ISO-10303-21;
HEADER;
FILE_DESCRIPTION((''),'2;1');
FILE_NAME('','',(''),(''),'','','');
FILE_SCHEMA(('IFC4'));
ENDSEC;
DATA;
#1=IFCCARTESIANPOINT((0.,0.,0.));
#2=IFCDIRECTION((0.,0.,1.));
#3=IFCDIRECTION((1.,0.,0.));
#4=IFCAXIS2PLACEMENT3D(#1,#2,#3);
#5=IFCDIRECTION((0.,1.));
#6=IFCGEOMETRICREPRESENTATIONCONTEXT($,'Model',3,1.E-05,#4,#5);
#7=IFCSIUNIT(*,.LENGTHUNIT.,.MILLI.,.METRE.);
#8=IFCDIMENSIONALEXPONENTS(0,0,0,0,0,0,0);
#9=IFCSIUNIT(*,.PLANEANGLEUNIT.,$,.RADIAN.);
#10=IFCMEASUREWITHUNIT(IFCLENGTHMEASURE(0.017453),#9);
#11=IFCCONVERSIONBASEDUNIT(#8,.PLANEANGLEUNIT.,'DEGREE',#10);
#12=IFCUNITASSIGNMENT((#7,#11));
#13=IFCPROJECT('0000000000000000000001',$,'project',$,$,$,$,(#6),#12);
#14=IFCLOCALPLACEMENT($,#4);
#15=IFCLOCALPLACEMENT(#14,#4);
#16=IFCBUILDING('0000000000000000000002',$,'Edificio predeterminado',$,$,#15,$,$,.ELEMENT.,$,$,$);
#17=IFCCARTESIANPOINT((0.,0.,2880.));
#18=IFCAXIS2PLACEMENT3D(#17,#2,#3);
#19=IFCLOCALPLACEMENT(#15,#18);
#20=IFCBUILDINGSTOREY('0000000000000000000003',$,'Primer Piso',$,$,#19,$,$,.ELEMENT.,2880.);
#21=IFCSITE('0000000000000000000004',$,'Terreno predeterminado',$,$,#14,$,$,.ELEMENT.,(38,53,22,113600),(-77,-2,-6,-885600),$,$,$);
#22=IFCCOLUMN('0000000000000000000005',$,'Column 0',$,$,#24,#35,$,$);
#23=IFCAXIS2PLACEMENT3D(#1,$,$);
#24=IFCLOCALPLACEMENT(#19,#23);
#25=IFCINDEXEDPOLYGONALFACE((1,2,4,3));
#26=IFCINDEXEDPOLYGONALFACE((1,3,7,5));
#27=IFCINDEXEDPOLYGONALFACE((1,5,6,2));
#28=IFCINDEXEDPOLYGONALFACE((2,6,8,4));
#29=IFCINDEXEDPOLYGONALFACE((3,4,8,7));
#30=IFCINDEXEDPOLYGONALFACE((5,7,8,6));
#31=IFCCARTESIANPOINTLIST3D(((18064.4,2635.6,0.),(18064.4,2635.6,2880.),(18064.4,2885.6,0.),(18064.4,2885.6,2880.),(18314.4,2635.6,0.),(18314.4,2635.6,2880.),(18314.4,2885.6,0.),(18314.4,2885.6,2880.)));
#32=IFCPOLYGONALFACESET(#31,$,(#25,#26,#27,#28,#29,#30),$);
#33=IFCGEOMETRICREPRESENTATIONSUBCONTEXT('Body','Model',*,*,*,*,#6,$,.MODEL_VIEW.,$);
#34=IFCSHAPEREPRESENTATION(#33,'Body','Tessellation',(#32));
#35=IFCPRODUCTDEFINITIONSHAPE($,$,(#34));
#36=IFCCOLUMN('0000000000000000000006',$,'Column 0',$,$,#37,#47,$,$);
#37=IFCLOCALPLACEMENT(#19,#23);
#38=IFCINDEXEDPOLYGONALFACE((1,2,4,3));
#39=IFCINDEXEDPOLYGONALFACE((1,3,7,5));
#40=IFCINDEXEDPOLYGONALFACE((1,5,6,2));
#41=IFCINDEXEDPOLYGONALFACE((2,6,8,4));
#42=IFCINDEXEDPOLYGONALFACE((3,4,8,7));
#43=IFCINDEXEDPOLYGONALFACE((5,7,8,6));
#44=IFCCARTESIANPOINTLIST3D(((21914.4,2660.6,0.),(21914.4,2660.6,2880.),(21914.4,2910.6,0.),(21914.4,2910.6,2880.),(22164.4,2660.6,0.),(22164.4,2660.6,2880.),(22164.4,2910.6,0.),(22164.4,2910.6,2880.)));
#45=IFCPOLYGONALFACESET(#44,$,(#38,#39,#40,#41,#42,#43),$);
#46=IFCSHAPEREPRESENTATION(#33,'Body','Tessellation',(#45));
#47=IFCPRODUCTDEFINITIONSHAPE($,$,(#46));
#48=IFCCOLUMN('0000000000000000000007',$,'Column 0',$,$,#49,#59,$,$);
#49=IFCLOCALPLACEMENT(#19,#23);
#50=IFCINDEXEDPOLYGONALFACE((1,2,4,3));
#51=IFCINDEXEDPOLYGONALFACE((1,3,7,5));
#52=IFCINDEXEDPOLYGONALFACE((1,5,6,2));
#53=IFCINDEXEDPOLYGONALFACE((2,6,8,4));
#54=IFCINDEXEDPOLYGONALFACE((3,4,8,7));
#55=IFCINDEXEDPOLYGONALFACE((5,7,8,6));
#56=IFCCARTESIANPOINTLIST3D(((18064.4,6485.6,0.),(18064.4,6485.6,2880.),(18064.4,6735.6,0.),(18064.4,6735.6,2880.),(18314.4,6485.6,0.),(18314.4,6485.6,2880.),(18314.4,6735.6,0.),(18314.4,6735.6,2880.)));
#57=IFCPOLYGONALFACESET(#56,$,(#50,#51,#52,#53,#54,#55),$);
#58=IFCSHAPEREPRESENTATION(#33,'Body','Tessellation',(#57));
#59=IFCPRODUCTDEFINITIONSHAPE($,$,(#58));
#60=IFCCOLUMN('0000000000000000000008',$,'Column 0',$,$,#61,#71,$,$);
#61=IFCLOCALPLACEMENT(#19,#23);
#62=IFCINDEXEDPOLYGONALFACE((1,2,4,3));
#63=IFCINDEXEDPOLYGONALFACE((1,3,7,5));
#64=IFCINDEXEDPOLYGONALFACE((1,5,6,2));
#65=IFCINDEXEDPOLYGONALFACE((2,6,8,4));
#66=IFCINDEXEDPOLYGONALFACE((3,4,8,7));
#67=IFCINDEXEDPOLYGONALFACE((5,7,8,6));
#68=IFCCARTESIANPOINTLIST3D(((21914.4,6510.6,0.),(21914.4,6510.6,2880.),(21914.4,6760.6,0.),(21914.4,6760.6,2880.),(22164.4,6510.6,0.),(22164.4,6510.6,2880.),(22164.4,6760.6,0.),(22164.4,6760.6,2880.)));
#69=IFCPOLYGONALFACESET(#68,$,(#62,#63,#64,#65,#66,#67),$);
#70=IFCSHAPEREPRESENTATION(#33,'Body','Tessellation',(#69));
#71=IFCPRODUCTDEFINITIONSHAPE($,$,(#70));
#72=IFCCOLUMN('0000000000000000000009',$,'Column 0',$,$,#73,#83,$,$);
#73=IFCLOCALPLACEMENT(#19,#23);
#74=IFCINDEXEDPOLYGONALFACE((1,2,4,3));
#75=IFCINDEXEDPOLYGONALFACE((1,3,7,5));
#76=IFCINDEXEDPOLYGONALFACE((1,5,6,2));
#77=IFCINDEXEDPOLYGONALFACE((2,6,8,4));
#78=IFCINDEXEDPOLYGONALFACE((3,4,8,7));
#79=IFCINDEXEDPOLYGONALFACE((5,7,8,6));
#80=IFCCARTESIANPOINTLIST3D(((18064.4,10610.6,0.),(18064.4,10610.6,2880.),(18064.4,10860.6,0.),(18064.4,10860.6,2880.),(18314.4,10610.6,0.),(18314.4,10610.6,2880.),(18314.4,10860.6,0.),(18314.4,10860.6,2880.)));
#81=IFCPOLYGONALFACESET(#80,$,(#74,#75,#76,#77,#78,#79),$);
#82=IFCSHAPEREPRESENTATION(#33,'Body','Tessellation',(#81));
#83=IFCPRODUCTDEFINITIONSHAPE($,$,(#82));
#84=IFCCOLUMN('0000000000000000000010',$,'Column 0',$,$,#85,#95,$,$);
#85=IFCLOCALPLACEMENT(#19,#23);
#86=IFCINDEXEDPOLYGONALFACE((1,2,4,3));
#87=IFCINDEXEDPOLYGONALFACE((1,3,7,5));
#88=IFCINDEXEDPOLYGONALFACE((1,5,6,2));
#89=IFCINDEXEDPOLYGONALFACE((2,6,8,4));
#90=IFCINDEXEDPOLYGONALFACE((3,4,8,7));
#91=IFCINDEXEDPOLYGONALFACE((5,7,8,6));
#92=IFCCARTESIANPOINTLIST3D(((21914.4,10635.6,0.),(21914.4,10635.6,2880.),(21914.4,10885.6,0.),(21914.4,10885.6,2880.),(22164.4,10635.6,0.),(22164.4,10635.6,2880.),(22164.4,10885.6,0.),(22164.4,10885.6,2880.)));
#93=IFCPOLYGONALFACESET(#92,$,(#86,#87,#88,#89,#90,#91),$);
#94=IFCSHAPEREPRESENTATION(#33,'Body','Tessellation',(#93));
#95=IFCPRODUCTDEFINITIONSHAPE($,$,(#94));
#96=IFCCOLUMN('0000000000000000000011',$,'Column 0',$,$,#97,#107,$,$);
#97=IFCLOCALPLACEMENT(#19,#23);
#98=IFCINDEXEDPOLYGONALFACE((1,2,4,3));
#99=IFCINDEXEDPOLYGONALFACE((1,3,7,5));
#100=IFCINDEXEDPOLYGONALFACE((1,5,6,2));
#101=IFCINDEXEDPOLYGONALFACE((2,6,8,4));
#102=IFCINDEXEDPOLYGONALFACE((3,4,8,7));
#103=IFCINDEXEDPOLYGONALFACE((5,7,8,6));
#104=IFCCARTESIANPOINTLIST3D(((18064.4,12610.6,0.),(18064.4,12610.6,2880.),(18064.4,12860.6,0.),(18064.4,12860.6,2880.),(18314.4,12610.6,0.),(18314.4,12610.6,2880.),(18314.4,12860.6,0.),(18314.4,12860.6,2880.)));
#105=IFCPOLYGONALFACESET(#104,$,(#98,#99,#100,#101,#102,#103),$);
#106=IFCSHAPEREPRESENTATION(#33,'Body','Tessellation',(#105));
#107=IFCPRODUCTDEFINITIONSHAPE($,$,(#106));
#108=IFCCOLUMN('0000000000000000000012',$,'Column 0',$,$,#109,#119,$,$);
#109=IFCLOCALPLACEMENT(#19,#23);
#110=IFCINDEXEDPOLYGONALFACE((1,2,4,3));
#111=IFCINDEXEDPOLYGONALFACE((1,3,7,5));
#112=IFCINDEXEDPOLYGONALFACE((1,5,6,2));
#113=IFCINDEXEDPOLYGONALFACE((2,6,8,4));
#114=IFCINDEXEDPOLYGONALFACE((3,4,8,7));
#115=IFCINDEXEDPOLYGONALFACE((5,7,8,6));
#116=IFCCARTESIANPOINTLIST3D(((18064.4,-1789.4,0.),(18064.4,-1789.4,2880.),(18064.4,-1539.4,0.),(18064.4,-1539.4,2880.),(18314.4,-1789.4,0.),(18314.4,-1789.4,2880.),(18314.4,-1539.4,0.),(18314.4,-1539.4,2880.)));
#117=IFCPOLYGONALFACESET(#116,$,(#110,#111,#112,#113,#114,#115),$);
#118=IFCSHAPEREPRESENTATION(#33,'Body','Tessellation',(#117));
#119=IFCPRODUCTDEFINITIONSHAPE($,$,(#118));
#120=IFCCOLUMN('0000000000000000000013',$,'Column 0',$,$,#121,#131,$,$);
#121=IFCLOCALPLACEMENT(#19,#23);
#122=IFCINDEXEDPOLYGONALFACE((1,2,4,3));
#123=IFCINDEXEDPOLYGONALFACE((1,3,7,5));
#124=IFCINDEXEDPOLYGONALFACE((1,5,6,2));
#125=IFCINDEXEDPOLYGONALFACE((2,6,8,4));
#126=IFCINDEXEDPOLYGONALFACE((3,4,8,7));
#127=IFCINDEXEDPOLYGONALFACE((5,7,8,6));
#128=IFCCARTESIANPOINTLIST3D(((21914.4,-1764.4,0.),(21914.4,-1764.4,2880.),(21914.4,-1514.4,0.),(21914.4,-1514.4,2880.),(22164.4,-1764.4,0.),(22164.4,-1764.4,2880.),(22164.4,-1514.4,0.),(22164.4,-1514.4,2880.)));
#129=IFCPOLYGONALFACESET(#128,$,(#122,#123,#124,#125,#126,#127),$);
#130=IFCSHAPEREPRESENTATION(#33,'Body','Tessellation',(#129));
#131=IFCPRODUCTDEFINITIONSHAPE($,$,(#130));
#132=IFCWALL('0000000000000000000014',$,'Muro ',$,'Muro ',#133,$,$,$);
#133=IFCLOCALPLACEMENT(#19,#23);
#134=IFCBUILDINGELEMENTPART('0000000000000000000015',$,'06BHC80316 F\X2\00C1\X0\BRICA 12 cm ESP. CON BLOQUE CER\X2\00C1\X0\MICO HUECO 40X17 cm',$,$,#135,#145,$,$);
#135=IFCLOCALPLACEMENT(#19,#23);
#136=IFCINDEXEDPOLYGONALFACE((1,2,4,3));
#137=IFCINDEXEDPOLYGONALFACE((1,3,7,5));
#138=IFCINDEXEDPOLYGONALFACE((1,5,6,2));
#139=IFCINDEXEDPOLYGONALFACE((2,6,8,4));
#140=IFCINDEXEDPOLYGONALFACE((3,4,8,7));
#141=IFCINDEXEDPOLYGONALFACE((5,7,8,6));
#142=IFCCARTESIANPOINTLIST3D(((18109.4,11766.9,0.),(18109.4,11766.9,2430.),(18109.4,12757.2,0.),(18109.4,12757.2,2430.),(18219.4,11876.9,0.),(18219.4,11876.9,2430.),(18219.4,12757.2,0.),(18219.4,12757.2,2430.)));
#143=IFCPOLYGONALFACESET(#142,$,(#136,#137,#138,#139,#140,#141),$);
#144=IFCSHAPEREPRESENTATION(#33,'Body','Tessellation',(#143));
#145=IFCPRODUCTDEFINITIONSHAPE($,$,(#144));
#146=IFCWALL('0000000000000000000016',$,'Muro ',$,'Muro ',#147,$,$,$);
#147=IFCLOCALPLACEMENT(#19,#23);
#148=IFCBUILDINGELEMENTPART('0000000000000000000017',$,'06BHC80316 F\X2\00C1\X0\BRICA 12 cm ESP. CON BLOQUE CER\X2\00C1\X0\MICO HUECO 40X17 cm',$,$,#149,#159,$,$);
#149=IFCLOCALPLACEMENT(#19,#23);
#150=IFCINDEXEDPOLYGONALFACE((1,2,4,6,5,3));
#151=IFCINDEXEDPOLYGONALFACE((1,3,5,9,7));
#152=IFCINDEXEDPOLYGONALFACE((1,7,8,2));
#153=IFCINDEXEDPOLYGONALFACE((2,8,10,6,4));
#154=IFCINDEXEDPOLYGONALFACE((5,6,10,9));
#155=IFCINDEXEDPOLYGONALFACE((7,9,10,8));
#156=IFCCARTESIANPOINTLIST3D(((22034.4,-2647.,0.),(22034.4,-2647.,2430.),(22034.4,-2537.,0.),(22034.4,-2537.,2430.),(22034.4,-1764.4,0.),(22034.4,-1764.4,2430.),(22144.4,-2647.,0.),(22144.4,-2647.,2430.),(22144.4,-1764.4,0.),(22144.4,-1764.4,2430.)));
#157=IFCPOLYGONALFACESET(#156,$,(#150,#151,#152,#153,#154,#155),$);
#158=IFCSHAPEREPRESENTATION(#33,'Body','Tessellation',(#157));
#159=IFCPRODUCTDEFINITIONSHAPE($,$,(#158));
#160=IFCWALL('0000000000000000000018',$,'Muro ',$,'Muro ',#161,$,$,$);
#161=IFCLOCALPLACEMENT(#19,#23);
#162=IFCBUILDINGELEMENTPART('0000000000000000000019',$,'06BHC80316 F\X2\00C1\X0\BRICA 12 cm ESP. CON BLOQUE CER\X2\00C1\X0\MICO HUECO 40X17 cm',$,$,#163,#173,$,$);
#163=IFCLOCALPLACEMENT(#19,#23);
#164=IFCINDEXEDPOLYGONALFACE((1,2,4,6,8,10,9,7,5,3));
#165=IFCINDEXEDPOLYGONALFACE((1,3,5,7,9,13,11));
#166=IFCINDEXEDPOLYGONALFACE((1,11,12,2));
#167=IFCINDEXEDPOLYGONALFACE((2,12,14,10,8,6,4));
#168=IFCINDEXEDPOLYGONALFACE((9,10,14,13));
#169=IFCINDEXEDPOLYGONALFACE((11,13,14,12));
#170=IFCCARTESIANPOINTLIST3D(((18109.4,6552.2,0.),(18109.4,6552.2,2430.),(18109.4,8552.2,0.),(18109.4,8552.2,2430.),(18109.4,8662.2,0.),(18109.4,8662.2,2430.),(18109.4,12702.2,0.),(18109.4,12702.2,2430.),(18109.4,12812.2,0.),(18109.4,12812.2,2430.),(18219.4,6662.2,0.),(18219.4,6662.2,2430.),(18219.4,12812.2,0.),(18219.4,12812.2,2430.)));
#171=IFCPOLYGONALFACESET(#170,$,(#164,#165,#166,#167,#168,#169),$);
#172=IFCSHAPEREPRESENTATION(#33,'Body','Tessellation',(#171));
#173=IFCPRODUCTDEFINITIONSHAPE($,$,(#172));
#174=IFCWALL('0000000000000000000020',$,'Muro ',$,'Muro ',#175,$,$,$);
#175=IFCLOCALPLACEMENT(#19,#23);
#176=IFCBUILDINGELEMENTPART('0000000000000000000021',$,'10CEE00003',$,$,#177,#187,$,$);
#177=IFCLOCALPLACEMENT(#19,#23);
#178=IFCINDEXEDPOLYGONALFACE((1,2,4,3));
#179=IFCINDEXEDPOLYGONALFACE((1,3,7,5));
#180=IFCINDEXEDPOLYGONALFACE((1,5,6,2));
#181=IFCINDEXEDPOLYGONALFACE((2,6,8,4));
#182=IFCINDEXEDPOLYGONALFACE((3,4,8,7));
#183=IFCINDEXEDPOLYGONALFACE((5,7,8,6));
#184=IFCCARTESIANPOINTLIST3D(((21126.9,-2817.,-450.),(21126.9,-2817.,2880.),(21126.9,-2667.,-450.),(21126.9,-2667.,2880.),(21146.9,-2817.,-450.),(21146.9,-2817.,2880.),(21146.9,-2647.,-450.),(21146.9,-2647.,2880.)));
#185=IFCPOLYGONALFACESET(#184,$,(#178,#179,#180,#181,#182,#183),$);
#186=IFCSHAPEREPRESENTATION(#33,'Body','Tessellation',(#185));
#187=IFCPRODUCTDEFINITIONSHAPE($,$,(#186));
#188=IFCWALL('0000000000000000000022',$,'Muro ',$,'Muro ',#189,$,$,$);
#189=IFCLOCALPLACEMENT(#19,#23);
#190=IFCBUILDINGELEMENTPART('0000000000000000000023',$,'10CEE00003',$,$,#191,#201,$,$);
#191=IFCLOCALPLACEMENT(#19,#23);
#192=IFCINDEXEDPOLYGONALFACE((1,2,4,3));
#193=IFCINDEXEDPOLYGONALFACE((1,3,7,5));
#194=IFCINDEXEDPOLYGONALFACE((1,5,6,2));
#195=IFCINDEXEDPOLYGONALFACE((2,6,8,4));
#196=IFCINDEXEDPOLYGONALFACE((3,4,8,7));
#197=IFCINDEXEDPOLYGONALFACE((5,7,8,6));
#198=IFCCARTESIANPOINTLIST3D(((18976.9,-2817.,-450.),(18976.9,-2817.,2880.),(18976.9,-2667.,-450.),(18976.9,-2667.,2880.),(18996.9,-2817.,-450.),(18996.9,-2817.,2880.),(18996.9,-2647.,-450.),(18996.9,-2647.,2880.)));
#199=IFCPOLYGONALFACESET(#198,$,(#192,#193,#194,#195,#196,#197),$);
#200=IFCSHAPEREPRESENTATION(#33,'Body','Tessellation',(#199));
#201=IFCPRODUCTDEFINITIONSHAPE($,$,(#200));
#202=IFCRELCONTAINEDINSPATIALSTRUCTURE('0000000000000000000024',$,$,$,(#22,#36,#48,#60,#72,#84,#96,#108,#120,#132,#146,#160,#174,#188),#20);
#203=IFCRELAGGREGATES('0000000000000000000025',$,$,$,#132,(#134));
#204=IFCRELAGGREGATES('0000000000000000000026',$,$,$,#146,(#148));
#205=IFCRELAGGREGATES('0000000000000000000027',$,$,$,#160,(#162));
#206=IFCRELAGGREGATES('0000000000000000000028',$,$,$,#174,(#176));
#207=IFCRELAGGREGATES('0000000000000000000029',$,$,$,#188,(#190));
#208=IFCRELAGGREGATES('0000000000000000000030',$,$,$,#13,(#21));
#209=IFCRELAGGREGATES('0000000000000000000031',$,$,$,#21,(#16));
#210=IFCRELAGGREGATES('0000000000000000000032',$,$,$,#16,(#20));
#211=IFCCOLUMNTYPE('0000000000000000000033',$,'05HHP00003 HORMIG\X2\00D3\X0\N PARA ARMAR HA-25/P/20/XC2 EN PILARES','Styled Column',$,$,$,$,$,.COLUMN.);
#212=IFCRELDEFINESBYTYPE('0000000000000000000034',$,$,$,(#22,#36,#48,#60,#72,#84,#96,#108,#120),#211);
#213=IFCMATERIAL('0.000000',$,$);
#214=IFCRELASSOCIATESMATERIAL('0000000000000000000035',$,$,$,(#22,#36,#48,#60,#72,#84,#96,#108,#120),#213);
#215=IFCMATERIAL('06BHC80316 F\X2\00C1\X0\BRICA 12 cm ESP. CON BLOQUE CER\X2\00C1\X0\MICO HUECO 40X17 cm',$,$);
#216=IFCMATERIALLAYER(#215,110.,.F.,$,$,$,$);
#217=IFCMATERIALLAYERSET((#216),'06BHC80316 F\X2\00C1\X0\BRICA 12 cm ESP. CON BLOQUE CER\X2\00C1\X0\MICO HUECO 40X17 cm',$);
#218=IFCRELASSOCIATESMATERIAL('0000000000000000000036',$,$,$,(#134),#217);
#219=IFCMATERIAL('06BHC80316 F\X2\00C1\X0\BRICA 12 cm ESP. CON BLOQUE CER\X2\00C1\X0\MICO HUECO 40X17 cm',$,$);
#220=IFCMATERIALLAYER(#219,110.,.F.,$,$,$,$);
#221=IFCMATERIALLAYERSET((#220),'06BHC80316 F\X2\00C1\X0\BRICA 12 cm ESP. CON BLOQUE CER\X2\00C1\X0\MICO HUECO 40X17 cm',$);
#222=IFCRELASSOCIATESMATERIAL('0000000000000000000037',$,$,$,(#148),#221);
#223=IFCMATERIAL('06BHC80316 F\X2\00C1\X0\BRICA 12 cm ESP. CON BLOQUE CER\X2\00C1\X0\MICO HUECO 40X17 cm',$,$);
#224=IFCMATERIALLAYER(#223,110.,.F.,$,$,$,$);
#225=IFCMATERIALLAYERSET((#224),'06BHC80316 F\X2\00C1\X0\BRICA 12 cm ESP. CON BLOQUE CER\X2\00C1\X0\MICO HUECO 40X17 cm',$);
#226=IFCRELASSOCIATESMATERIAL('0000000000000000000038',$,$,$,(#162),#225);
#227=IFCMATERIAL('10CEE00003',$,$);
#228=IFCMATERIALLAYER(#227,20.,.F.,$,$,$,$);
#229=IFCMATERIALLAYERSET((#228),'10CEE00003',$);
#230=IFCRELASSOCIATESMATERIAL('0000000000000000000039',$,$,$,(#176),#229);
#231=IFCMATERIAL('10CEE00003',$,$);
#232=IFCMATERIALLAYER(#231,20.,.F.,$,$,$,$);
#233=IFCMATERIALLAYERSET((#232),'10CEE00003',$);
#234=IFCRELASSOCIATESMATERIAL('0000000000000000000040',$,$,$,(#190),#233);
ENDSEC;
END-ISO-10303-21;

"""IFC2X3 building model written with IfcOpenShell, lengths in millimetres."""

from ifc_helpers import new_model, entity, si_unit, converted_unit, direction, frame, origin_with_axes, place, context, subcontext, project, spatial, polyline, outline, extrude, clip, bounded_halfspace, material, layer, layer_set, layer_usage, type_object, element, aggregate, save


model = new_model("IFC2X3")

# Units and contexts
model_context = context("Model", 3, precision=1e-05, world=origin_with_axes(), true_north=direction((0.0, 1.0)))
body_context = subcontext(model_context, "Body", "Model", "MODEL_VIEW")
ifc_project = project(units=[si_unit("LENGTHUNIT", "METRE", prefix="MILLI"), converted_unit("PLANEANGLEUNIT", "DEGREE", entity("IfcLengthMeasure", 0.017453), si_unit("PLANEANGLEUNIT", "RADIAN"), dimensions=[0, 0, 0, 0, 0, 0, 0])], contexts=[model_context])

# Site, building, storey
site_placement = place(None, origin_with_axes())
site = spatial("IfcSite", under=ifc_project, at=site_placement, Name="Terreno predeterminado", CompositionType="ELEMENT", RefLatitude=(38, 53, 22, 113600), RefLongitude=(-77, -2, -6, -885600))
building_placement = place(site_placement, origin_with_axes())
building = spatial("IfcBuilding", under=site, at=building_placement, Name="Edificio predeterminado", CompositionType="ELEMENT")
storey_placement = place(building_placement, frame((0.0, 0.0, 2880.0), z_axis=(0.0, 0.0, 1.0), x_axis=(1.0, 0.0, 0.0)))
storey = spatial("IfcBuildingStorey", under=building, at=storey_placement, Name="Primer Piso", CompositionType="ELEMENT", Elevation=2880.0)

# Columns
ifc_material_1 = material(Name="0.000000")
column_type = type_object("IfcColumnType", Name="05HHP00003 HORMIGÓN PARA ARMAR HA-25/P/20/XC2 EN PILARES", Description="Styled Column", PredefinedType="COLUMN")
for number, where, z_axis, x_axis, name in (
    (1, (18189.4, 2760.6, 0.0), (0.0, 0.0, 1.0), (1.0, 0.0, 0.0), "Column 0"),
    (2, (22039.4, 2785.6, 0.0), (0.0, 0.0, 1.0), (1.0, 0.0, 0.0), "Column 0"),
    (3, (18189.4, 6610.6, 0.0), (0.0, 0.0, 1.0), (1.0, 0.0, 0.0), "Column 0"),
    (4, (22039.4, 6635.6, 0.0), (0.0, 0.0, 1.0), (1.0, 0.0, 0.0), "Column 0"),
    (5, (18189.4, 10735.6, 0.0), (0.0, 0.0, 1.0), (1.0, 0.0, 0.0), "Column 0"),
    (6, (22039.4, 10760.6, 0.0), (0.0, 0.0, 1.0), (1.0, 0.0, 0.0), "Column 0"),
    (7, (18189.4, 12735.6, 0.0), (0.0, 0.0, 1.0), (1.0, 0.0, 0.0), "Column 0"),
    (8, (18189.4, -1664.4, 0.0), (0.0, 0.0, 1.0), (1.0, 0.0, 0.0), "Column 0"),
    (9, (22039.4, -1639.4, 0.0), (0.0, 0.0, 1.0), (1.0, 0.0, 0.0), "Column 0"),
):
    element("IfcColumn", number, at=place(storey_placement, frame(where, z_axis=z_axis, x_axis=x_axis)), inside=storey, type_object=column_type, material=ifc_material_1, Name=name, context=body_context, shape_type="SweptSolid", body=[
        extrude(outline(polyline([(-125.0, -125.0), (125.0, -125.0), (125.0, 125.0), (-125.0, 125.0), (-125.0, -125.0)])), origin_with_axes(), (0.0, 0.0, 1.0), 2880.0),
    ])

# Walls, building element parts
wall_1_placement = place(storey_placement, frame((18164.4, 11821.9, 0.0), z_axis=(0.0, 0.0, 1.0), x_axis=(0.0, 1.0, 0.0)))
wall_1 = element("IfcWall", 10, at=wall_1_placement, inside=storey, Name="Muro ", ObjectType="Muro ")
ifc_material_2 = material(Name="06BHC80316 FÁBRICA 12 cm ESP. CON BLOQUE CERÁMICO HUECO 40X17 cm")
ifc_layer_1 = layer(ifc_material_2, 110.0, ventilated=False)
ifc_layer_set_1 = layer_set([ifc_layer_1], Name="06BHC80316 FÁBRICA 12 cm ESP. CON BLOQUE CERÁMICO HUECO 40X17 cm")
ifc_layer_usage_1 = layer_usage(ifc_layer_set_1, "AXIS2", "NEGATIVE", -55.0)
building_element_part_1_placement = place(wall_1_placement, origin_with_axes())
building_element_part_1 = element("IfcBuildingElementPart", 11, at=building_element_part_1_placement, material=ifc_layer_usage_1, Name="06BHC80316 FÁBRICA 12 cm ESP. CON BLOQUE CERÁMICO HUECO 40X17 cm", context=body_context, shape_type="SweptSolid", body=[
    extrude(outline(polyline([(935.2, 55.0), (935.2, -55.0), (55.0, -55.0), (-55.0, 55.0), (935.2, 55.0)])), origin_with_axes(), (0.0, 0.0, 1.0), 2430.0),
])
aggregate(wall_1, [building_element_part_1])
wall_2_placement = place(storey_placement, frame((22089.4, -1764.4, 0.0), z_axis=(0.0, 0.0, 1.0), x_axis=(0.0, -1.0, 0.0)))
wall_2 = element("IfcWall", 12, at=wall_2_placement, inside=storey, Name="Muro ", ObjectType="Muro ")
ifc_material_3 = material(Name="06BHC80316 FÁBRICA 12 cm ESP. CON BLOQUE CERÁMICO HUECO 40X17 cm")
ifc_layer_2 = layer(ifc_material_3, 110.0, ventilated=False)
ifc_layer_set_2 = layer_set([ifc_layer_2], Name="06BHC80316 FÁBRICA 12 cm ESP. CON BLOQUE CERÁMICO HUECO 40X17 cm")
ifc_layer_usage_2 = layer_usage(ifc_layer_set_2, "AXIS2", "NEGATIVE", -55.0)
building_element_part_2_placement = place(wall_2_placement, origin_with_axes())
building_element_part_2 = element("IfcBuildingElementPart", 13, at=building_element_part_2_placement, material=ifc_layer_usage_2, Name="06BHC80316 FÁBRICA 12 cm ESP. CON BLOQUE CERÁMICO HUECO 40X17 cm", context=body_context, shape_type="SweptSolid", body=[
    extrude(outline(polyline([(882.6, 55.0), (882.6, -55.0), (772.6, -55.0), (0.0, -55.0), (0.0, 55.0), (882.6, 55.0)])), origin_with_axes(), (0.0, 0.0, 1.0), 2430.0),
])
aggregate(wall_2, [building_element_part_2])
wall_3_placement = place(storey_placement, frame((18164.4, 12757.2, 0.0), z_axis=(0.0, 0.0, 1.0), x_axis=(0.0, -1.0, 0.0)))
wall_3 = element("IfcWall", 14, at=wall_3_placement, inside=storey, Name="Muro ", ObjectType="Muro ")
ifc_material_4 = material(Name="06BHC80316 FÁBRICA 12 cm ESP. CON BLOQUE CERÁMICO HUECO 40X17 cm")
ifc_layer_3 = layer(ifc_material_4, 110.0, ventilated=False)
ifc_layer_set_3 = layer_set([ifc_layer_3], Name="06BHC80316 FÁBRICA 12 cm ESP. CON BLOQUE CERÁMICO HUECO 40X17 cm")
ifc_layer_usage_3 = layer_usage(ifc_layer_set_3, "AXIS2", "NEGATIVE", -55.0)
building_element_part_3_placement = place(wall_3_placement, origin_with_axes())
building_element_part_3 = element("IfcBuildingElementPart", 15, at=building_element_part_3_placement, material=ifc_layer_usage_3, Name="06BHC80316 FÁBRICA 12 cm ESP. CON BLOQUE CERÁMICO HUECO 40X17 cm", context=body_context, shape_type="SweptSolid", body=[
    extrude(outline(polyline([(6095.0, 55.0), (6205.0, -55.0), (4205.0, -55.0), (4095.0, -55.0), (55.0, -55.0), (-55.0, -55.0), (-55.0, 55.0), (6095.0, 55.0)])), origin_with_axes(), (0.0, 0.0, 1.0), 2430.0),
])
aggregate(wall_3, [building_element_part_3])
wall_4_placement = place(storey_placement, frame((21201.9, -2817.0, 0.0), z_axis=(0.0, 0.0, 1.0), x_axis=(0.0, 1.0, 0.0)))
wall_4 = element("IfcWall", 16, at=wall_4_placement, inside=storey, Name="Muro ", ObjectType="Muro ")
ifc_material_5 = material(Name="10CEE00003")
ifc_layer_4 = layer(ifc_material_5, 20.0, ventilated=False)
ifc_layer_set_4 = layer_set([ifc_layer_4], Name="10CEE00003")
ifc_layer_usage_4 = layer_usage(ifc_layer_set_4, "AXIS2", "NEGATIVE", -75.0)
building_element_part_4_placement = place(wall_4_placement, origin_with_axes())
building_element_part_4 = element("IfcBuildingElementPart", 17, at=building_element_part_4_placement, material=ifc_layer_usage_4, Name="10CEE00003", context=body_context, shape_type="Clipping", body=[
    clip(clip(extrude(outline(polyline([(150.0, 75.0), (170.0, 55.0), (0.0, 55.0), (0.0, 75.0), (150.0, 75.0)])), frame((0.0, 0.0, -450.0), z_axis=(0.0, 0.0, 1.0), x_axis=(1.0, 0.0, 0.0)), (0.0, 0.0, 1.0), 3330.0), bounded_halfspace(frame((0.0, 0.0, -450.0), z_axis=(0.0, 0.0, 1.0), x_axis=(1.0, 0.0, 0.0)), True, origin_with_axes(), polyline([(-150.0, -150.0), (375.0, -150.0), (375.0, 150.0), (-150.0, 150.0), (-150.0, -150.0)]))), bounded_halfspace(frame((0.0, 0.0, 2880.0), z_axis=(0.0, 0.0, 1.0), x_axis=(1.0, 0.0, 0.0)), False, origin_with_axes(), polyline([(-150.0, -150.0), (375.0, -150.0), (375.0, 150.0), (-150.0, 150.0), (-150.0, -150.0)]))),
])
aggregate(wall_4, [building_element_part_4])
wall_5_placement = place(storey_placement, frame((19051.9, -2817.0, 0.0), z_axis=(0.0, 0.0, 1.0), x_axis=(0.0, 1.0, 0.0)))
wall_5 = element("IfcWall", 18, at=wall_5_placement, inside=storey, Name="Muro ", ObjectType="Muro ")
ifc_material_6 = material(Name="10CEE00003")
ifc_layer_5 = layer(ifc_material_6, 20.0, ventilated=False)
ifc_layer_set_5 = layer_set([ifc_layer_5], Name="10CEE00003")
ifc_layer_usage_5 = layer_usage(ifc_layer_set_5, "AXIS2", "NEGATIVE", -75.0)
building_element_part_5_placement = place(wall_5_placement, origin_with_axes())
building_element_part_5 = element("IfcBuildingElementPart", 19, at=building_element_part_5_placement, material=ifc_layer_usage_5, Name="10CEE00003", context=body_context, shape_type="Clipping", body=[
    clip(clip(extrude(outline(polyline([(150.0, 75.0), (170.0, 55.0), (0.0, 55.0), (0.0, 75.0), (150.0, 75.0)])), frame((0.0, 0.0, -450.0), z_axis=(0.0, 0.0, 1.0), x_axis=(1.0, 0.0, 0.0)), (0.0, 0.0, 1.0), 3330.0), bounded_halfspace(frame((0.0, 0.0, -450.0), z_axis=(0.0, 0.0, 1.0), x_axis=(1.0, 0.0, 0.0)), True, origin_with_axes(), polyline([(-150.0, -150.0), (375.0, -150.0), (375.0, 150.0), (-150.0, 150.0), (-150.0, -150.0)]))), bounded_halfspace(frame((0.0, 0.0, 2880.0), z_axis=(0.0, 0.0, 1.0), x_axis=(1.0, 0.0, 0.0)), False, origin_with_axes(), polyline([(-150.0, -150.0), (375.0, -150.0), (375.0, 150.0), (-150.0, 150.0), (-150.0, -150.0)]))),
])
aggregate(wall_5, [building_element_part_5])

save(model, "model.ifc")
